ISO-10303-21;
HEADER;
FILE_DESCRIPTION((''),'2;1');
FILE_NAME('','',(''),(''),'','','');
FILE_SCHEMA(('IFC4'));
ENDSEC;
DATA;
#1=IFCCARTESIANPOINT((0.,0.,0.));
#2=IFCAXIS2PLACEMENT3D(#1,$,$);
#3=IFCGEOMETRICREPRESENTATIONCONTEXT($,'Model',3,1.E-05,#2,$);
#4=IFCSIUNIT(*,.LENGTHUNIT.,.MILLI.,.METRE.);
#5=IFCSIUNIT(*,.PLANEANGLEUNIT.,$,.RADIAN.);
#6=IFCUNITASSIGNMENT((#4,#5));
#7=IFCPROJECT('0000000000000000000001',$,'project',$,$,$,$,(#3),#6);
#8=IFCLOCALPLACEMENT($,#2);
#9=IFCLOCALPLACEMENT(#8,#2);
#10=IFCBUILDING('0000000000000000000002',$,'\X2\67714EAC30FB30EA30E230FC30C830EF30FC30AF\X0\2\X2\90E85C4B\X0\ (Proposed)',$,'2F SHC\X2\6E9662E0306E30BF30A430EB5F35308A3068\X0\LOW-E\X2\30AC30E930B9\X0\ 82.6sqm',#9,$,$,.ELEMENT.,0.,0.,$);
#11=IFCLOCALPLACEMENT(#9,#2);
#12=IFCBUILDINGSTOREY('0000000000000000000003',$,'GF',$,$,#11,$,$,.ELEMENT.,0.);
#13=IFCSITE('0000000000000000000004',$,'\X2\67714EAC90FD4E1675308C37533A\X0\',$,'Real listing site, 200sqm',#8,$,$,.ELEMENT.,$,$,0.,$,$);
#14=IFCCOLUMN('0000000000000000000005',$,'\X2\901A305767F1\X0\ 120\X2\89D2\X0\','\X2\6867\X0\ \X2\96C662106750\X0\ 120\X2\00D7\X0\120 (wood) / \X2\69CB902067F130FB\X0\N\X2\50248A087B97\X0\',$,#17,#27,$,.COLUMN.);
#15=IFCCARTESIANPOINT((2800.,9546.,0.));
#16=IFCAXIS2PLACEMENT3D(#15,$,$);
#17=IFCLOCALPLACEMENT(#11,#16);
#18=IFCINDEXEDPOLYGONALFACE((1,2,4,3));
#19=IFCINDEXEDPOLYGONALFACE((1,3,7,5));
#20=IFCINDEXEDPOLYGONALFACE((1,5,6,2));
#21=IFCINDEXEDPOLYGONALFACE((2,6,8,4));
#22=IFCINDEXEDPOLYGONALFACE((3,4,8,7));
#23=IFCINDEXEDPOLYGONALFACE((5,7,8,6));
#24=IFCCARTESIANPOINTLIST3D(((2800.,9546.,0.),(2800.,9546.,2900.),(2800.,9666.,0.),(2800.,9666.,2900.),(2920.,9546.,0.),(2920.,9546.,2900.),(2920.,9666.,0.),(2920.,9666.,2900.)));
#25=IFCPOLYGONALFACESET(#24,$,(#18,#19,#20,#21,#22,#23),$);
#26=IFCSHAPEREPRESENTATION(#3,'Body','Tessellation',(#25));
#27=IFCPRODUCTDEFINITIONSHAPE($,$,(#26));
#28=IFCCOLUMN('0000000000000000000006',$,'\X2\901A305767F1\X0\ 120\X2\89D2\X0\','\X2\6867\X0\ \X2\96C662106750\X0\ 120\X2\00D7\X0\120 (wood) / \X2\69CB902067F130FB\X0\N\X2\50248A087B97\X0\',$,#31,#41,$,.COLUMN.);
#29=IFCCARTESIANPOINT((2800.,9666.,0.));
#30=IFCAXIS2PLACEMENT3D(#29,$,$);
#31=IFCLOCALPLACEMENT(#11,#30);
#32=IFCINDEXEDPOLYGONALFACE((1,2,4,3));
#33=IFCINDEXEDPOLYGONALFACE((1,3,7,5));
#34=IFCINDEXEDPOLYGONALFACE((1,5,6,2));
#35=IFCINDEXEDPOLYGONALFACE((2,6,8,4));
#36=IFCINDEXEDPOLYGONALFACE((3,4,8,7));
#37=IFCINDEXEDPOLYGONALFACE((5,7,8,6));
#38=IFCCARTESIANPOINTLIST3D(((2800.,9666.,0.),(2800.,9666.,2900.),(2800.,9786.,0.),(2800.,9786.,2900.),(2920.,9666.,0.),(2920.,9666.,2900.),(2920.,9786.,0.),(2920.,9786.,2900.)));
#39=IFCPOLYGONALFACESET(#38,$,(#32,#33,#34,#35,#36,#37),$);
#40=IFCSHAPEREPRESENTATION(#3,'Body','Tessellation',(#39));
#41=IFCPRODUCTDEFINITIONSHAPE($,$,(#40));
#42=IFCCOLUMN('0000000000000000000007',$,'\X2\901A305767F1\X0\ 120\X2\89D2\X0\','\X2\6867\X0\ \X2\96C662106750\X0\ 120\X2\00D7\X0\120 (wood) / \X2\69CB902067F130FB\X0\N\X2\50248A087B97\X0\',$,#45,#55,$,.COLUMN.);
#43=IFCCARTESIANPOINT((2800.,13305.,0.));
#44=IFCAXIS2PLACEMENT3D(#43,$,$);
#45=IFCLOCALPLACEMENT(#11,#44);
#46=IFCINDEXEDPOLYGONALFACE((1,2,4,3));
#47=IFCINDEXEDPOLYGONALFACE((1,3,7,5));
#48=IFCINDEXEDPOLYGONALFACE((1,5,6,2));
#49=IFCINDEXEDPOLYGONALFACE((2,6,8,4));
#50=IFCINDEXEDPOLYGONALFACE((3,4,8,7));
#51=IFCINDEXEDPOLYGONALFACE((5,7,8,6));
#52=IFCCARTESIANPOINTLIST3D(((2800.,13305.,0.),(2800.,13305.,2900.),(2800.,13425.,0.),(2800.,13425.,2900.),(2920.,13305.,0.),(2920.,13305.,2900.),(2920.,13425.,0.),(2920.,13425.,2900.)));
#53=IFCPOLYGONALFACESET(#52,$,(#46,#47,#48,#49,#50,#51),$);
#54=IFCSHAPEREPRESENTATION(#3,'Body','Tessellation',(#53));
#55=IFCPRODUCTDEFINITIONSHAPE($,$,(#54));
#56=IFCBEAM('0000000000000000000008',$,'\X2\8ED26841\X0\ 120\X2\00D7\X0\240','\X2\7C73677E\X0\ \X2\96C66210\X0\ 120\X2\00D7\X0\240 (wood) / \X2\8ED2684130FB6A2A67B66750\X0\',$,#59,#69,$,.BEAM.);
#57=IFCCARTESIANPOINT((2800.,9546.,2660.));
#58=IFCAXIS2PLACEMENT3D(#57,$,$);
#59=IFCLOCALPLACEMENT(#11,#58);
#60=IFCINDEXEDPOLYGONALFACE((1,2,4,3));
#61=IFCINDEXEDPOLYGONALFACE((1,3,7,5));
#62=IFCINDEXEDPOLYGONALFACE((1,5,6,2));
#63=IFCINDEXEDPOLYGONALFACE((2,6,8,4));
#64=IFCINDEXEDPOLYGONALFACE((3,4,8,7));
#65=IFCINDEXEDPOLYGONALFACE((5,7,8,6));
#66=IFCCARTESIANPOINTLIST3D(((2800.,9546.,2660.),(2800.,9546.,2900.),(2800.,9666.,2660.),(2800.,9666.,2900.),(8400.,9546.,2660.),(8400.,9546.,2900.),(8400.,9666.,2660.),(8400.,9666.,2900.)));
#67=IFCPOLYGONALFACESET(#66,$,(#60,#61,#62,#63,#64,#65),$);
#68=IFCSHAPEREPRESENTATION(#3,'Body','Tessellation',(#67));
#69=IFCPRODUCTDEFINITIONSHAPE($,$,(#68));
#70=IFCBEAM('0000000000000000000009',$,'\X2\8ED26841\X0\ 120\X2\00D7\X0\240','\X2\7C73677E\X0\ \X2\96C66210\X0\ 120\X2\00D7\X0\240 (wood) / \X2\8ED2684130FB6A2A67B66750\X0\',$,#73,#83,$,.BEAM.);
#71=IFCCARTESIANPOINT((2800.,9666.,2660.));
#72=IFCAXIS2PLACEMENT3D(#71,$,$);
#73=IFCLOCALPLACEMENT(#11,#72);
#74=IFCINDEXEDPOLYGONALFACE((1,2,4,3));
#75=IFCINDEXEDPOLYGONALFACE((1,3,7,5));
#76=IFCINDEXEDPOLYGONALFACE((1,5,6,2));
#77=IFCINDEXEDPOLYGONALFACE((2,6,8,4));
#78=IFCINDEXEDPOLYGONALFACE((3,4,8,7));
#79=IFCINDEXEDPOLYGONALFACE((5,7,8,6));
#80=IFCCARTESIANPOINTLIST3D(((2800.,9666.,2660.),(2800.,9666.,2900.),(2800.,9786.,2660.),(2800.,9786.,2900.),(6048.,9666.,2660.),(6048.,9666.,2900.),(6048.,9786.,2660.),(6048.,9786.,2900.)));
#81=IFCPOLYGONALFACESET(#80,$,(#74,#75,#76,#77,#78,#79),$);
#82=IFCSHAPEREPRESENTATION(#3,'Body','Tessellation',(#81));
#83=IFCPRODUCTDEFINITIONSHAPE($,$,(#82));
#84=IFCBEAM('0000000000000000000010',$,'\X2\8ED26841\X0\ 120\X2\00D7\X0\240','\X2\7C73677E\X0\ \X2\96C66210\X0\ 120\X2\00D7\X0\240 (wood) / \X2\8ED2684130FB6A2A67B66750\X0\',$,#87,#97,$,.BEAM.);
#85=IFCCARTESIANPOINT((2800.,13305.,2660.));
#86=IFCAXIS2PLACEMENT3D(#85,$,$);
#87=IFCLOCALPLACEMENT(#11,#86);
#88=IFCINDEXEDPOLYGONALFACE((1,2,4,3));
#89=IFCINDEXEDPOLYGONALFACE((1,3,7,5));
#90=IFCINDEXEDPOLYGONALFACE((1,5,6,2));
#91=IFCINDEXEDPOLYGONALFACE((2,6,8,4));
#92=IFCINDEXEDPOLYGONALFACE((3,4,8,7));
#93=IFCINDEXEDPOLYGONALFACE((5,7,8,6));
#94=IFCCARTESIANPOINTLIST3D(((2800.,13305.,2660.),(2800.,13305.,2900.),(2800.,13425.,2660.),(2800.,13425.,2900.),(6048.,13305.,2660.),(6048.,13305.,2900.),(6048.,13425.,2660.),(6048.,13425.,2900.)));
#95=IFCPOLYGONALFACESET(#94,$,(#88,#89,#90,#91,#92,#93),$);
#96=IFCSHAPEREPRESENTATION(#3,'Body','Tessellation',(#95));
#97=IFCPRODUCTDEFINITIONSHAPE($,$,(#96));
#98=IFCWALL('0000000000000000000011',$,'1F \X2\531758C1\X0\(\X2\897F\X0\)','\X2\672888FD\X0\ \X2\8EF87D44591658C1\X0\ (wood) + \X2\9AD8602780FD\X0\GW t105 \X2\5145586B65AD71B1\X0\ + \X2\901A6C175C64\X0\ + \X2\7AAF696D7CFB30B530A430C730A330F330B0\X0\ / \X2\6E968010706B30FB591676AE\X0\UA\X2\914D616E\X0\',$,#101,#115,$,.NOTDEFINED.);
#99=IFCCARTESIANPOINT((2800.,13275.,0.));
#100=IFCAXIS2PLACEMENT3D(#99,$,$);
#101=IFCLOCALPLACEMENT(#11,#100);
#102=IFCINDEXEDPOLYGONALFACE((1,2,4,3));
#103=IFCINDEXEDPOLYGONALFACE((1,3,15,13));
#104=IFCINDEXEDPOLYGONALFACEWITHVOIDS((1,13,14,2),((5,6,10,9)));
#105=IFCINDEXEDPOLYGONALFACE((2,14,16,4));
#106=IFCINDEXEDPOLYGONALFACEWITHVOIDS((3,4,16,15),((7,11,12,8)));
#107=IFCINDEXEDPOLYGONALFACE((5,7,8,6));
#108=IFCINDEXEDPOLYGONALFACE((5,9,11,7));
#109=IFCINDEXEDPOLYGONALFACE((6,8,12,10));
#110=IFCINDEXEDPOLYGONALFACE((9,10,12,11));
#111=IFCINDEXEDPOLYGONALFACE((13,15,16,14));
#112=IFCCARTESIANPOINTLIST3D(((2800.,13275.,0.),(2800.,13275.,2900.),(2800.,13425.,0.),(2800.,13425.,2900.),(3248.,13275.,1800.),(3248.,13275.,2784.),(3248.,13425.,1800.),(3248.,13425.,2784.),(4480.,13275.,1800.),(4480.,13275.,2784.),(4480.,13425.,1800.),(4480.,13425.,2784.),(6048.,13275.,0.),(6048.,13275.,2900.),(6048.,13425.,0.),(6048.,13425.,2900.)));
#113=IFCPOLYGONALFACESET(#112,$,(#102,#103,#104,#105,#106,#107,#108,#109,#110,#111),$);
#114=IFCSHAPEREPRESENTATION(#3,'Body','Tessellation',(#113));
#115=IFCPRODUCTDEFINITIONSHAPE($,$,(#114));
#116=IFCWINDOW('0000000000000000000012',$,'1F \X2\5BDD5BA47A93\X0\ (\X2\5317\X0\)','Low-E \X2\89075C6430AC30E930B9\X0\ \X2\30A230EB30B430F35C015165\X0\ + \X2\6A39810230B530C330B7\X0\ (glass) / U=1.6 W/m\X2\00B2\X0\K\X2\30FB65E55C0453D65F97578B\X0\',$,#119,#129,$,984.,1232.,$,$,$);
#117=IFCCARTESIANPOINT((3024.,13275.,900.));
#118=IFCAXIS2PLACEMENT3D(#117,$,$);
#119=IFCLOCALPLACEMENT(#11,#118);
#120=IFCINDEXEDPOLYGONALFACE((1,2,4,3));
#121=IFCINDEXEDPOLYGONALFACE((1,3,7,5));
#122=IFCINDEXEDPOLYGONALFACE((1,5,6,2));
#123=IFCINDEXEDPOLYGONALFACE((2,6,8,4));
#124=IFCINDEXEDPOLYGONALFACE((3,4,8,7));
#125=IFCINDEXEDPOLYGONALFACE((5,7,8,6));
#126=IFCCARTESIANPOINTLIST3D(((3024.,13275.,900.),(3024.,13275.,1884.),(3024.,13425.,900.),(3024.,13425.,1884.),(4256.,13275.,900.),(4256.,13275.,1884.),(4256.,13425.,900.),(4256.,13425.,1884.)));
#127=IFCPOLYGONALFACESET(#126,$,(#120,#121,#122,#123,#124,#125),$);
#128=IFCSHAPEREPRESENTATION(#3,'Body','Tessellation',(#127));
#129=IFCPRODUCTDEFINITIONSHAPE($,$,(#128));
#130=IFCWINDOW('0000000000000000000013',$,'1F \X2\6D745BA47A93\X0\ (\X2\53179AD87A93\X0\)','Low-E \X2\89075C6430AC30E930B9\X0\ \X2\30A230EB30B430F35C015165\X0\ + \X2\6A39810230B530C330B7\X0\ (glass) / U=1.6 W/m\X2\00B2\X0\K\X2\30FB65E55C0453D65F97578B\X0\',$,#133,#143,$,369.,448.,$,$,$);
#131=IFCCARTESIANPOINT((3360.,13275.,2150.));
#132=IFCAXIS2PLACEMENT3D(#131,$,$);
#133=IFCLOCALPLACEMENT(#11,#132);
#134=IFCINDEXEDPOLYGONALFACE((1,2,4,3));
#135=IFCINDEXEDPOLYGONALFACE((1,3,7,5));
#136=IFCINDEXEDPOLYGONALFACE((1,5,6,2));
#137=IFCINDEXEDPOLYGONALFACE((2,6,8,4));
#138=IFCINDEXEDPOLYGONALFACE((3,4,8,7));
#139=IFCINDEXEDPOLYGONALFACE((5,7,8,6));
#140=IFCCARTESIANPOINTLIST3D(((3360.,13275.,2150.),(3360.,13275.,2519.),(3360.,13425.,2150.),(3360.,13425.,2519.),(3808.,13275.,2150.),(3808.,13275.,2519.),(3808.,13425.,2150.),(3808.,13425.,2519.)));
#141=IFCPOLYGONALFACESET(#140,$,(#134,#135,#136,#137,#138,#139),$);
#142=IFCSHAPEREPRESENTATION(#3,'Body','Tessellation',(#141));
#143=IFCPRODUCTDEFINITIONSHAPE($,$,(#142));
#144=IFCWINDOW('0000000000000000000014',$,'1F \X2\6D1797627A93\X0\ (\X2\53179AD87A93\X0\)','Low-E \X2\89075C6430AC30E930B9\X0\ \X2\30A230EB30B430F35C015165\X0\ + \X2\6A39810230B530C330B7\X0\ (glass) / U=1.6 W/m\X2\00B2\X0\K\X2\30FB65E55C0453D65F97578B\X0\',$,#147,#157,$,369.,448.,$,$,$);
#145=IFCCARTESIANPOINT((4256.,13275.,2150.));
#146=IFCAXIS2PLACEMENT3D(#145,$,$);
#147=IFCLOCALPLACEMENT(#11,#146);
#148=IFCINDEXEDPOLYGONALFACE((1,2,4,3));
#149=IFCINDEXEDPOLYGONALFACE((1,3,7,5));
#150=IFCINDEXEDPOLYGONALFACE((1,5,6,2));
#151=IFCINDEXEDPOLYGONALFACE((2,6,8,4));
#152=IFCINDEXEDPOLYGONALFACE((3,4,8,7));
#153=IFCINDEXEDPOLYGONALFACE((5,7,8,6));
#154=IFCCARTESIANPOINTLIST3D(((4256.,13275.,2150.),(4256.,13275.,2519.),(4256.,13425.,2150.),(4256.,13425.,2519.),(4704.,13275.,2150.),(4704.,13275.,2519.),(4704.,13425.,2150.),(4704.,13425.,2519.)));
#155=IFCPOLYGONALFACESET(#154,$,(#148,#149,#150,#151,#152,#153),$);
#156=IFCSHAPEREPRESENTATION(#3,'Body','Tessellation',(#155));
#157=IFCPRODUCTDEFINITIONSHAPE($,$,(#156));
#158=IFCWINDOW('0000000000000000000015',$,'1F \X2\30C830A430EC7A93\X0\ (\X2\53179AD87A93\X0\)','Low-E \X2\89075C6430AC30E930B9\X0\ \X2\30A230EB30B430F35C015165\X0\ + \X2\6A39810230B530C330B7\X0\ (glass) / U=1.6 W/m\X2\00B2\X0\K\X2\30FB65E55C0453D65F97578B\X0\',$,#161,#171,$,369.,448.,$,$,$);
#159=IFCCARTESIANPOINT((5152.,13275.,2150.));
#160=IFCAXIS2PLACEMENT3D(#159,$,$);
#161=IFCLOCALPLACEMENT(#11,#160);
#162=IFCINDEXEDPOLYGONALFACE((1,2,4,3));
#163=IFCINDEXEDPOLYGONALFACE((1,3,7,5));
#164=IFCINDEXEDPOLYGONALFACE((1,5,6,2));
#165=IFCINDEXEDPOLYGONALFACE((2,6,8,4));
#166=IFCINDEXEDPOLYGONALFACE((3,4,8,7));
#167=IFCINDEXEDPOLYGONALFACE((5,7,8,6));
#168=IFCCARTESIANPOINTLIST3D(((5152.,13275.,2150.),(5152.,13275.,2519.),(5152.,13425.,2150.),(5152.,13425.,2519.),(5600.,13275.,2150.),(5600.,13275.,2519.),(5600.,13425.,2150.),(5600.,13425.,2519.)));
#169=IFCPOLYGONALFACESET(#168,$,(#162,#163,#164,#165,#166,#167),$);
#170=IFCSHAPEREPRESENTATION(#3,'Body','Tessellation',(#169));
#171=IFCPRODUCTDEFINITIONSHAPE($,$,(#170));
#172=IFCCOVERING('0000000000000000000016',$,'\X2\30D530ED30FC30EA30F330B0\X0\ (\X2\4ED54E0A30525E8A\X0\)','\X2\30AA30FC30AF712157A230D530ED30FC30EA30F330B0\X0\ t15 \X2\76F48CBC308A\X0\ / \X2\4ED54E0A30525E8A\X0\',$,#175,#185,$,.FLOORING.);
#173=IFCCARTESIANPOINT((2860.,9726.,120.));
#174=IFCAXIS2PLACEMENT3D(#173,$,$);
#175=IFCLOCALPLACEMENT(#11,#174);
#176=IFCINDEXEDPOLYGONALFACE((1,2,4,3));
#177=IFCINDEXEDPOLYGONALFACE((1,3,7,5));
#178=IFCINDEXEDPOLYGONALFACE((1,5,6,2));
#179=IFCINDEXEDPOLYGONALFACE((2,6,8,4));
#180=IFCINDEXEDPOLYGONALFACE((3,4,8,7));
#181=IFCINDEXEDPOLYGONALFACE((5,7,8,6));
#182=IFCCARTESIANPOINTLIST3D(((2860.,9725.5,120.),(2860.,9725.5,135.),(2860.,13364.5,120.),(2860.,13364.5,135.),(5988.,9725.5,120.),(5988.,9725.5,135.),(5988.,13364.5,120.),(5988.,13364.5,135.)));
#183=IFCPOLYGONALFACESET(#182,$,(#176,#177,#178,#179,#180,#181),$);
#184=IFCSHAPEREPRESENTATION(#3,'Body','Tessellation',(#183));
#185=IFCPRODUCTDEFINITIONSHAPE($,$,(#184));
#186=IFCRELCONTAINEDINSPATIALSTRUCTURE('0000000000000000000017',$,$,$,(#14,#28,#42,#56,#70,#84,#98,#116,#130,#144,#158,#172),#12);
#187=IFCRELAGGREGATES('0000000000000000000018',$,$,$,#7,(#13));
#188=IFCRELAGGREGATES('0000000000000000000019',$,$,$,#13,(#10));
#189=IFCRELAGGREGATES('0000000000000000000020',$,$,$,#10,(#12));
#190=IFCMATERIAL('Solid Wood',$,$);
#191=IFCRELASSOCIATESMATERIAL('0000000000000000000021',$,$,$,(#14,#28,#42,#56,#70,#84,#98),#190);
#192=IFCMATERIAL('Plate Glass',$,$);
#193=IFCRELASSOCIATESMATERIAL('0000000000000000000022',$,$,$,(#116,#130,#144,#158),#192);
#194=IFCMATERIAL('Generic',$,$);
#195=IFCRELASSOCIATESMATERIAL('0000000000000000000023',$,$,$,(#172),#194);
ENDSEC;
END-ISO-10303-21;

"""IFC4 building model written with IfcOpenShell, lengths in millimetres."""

from ifc_helpers import new_model, si_unit, frame, frame_2d, origin, place, context, project, spatial, rectangle, extrude, material, element, fill, save


model = new_model("IFC4")

# Units and contexts
model_context = context("Model", 3, precision=1e-05, world=origin())
ifc_project = project(units=[si_unit("LENGTHUNIT", "METRE", prefix="MILLI"), si_unit("PLANEANGLEUNIT", "RADIAN")], contexts=[model_context])

# Site, building, storey
site_placement = place(None, origin())
site = spatial("IfcSite", under=ifc_project, at=site_placement, Name="東京都世田谷区", ObjectType="Real listing site, 200sqm", CompositionType="ELEMENT", RefElevation=0.0)
building_placement = place(site_placement, origin())
building = spatial("IfcBuilding", under=site, at=building_placement, Name="東京・リモートワーク2部屋 (Proposed)", ObjectType="2F SHC準拠のタイル張りとLOW-Eガラス 82.6sqm", CompositionType="ELEMENT", ElevationOfRefHeight=0.0, ElevationOfTerrain=0.0)
storey_placement = place(building_placement, origin())
storey = spatial("IfcBuildingStorey", under=building, at=storey_placement, Name="GF", CompositionType="ELEMENT", Elevation=0.0)

# Columns
ifc_material_1 = material(Name="Solid Wood")
column_1_placement = place(storey_placement, frame((2800.0, 9546.0, 0.0)))
element("IfcColumn", 1, at=column_1_placement, inside=storey, material=ifc_material_1, Name="通し柱 120角", Description="桧 集成材 120×120 (wood) / 構造柱・N値計算", PredefinedType="COLUMN", context=model_context, shape_type="SweptSolid", body=[
    extrude(rectangle(XDim=120.0, YDim=120.0, at=frame_2d((60.0, 60.0))), frame((2800.0, 9546.0, 0.0)), (0.0, 0.0, 1.0), 2900.0),
])
column_2_placement = place(storey_placement, frame((2800.0, 9666.0, 0.0)))
element("IfcColumn", 2, at=column_2_placement, inside=storey, material=ifc_material_1, Name="通し柱 120角", Description="桧 集成材 120×120 (wood) / 構造柱・N値計算", PredefinedType="COLUMN", context=model_context, shape_type="SweptSolid", body=[
    extrude(rectangle(XDim=120.0, YDim=120.0, at=frame_2d((60.0, 60.0))), frame((2800.0, 9666.0, 0.0)), (0.0, 0.0, 1.0), 2900.0),
])
column_3_placement = place(storey_placement, frame((2800.0, 13305.0, 0.0)))
element("IfcColumn", 3, at=column_3_placement, inside=storey, material=ifc_material_1, Name="通し柱 120角", Description="桧 集成材 120×120 (wood) / 構造柱・N値計算", PredefinedType="COLUMN", context=model_context, shape_type="SweptSolid", body=[
    extrude(rectangle(XDim=120.0, YDim=120.0, at=frame_2d((60.0, 60.0))), frame((2800.0, 13305.0, 0.0)), (0.0, 0.0, 1.0), 2900.0),
])

# Beams
beam_1_placement = place(storey_placement, frame((2800.0, 9546.0, 2660.0)))
element("IfcBeam", 4, at=beam_1_placement, inside=storey, material=ifc_material_1, Name="軒桁 120×240", Description="米松 集成 120×240 (wood) / 軒桁・横架材", PredefinedType="BEAM", context=model_context, shape_type="SweptSolid", body=[
    extrude(rectangle(XDim=5600.0, YDim=120.0, at=frame_2d((2800.0, 60.0))), frame((2800.0, 9546.0, 2660.0)), (0.0, 0.0, 1.0), 240.0),
])
beam_2_placement = place(storey_placement, frame((2800.0, 9666.0, 2660.0)))
element("IfcBeam", 5, at=beam_2_placement, inside=storey, material=ifc_material_1, Name="軒桁 120×240", Description="米松 集成 120×240 (wood) / 軒桁・横架材", PredefinedType="BEAM", context=model_context, shape_type="SweptSolid", body=[
    extrude(rectangle(XDim=3248.0, YDim=120.0, at=frame_2d((1624.0, 60.0))), frame((2800.0, 9666.0, 2660.0)), (0.0, 0.0, 1.0), 240.0),
])
beam_3_placement = place(storey_placement, frame((2800.0, 13305.0, 2660.0)))
element("IfcBeam", 6, at=beam_3_placement, inside=storey, material=ifc_material_1, Name="軒桁 120×240", Description="米松 集成 120×240 (wood) / 軒桁・横架材", PredefinedType="BEAM", context=model_context, shape_type="SweptSolid", body=[
    extrude(rectangle(XDim=3248.0, YDim=120.0, at=frame_2d((1624.0, 60.0))), frame((2800.0, 13305.0, 2660.0)), (0.0, 0.0, 1.0), 240.0),
])

# Wall, openings, windows
wall_1_placement = place(storey_placement, frame((2800.0, 13275.0, 0.0)))
wall_1 = element("IfcWall", 7, at=wall_1_placement, inside=storey, material=ifc_material_1, Name="1F 北壁(西)", Description="木製 軸組外壁 (wood) + 高性能GW t105 充填断熱 + 通気層 + 窯業系サイディング / 準耐火・外皮UA配慮", PredefinedType="NOTDEFINED", context=model_context, shape_type="SweptSolid", body=[
    extrude(rectangle(XDim=3248.0, YDim=150.0, at=frame_2d((1624.0, 75.0))), frame((2800.0, 13275.0, 0.0)), (0.0, 0.0, 1.0), 2900.0),
])
opening_1_placement = place(storey_placement, frame((3024.0, 13275.0, 900.0)))
opening_1 = element("IfcOpeningElement", 8, at=opening_1_placement, cuts=wall_1, PredefinedType="NOTDEFINED", context=model_context, shape_type="SweptSolid", body=[
    extrude(rectangle(XDim=1232.0, YDim=150.0, at=frame_2d((616.0, 75.0))), frame((3024.0, 13275.0, 900.0)), (0.0, 0.0, 1.0), 984.0),
])
opening_2_placement = place(storey_placement, frame((3360.0, 13275.0, 2150.0)))
opening_2 = element("IfcOpeningElement", 9, at=opening_2_placement, cuts=wall_1, PredefinedType="NOTDEFINED", context=model_context, shape_type="SweptSolid", body=[
    extrude(rectangle(XDim=448.0, YDim=150.0, at=frame_2d((224.0, 75.0))), frame((3360.0, 13275.0, 2150.0)), (0.0, 0.0, 1.0), 369.0),
])
opening_3_placement = place(storey_placement, frame((4256.0, 13275.0, 2150.0)))
opening_3 = element("IfcOpeningElement", 10, at=opening_3_placement, cuts=wall_1, PredefinedType="NOTDEFINED", context=model_context, shape_type="SweptSolid", body=[
    extrude(rectangle(XDim=448.0, YDim=150.0, at=frame_2d((224.0, 75.0))), frame((4256.0, 13275.0, 2150.0)), (0.0, 0.0, 1.0), 369.0),
])
opening_4_placement = place(storey_placement, frame((5152.0, 13275.0, 2150.0)))
opening_4 = element("IfcOpeningElement", 11, at=opening_4_placement, cuts=wall_1, PredefinedType="NOTDEFINED", context=model_context, shape_type="SweptSolid", body=[
    extrude(rectangle(XDim=448.0, YDim=150.0, at=frame_2d((224.0, 75.0))), frame((5152.0, 13275.0, 2150.0)), (0.0, 0.0, 1.0), 369.0),
])
ifc_material_2 = material(Name="Plate Glass")
window_1_placement = place(storey_placement, frame((3024.0, 13275.0, 900.0)))
window_1 = element("IfcWindow", 12, at=window_1_placement, inside=storey, material=ifc_material_2, Name="1F 寝室窓 (北)", Description="Low-E 複層ガラス アルゴン封入 + 樹脂サッシ (glass) / U=1.6 W/m²K・日射取得型", OverallHeight=984.0, OverallWidth=1232.0, context=model_context, shape_type="SweptSolid", body=[
    extrude(rectangle(XDim=1232.0, YDim=150.0, at=frame_2d((616.0, 75.0))), frame((3024.0, 13275.0, 900.0)), (0.0, 0.0, 1.0), 984.0),
])
fill(opening_1, window_1)
window_2_placement = place(storey_placement, frame((3360.0, 13275.0, 2150.0)))
window_2 = element("IfcWindow", 13, at=window_2_placement, inside=storey, material=ifc_material_2, Name="1F 浴室窓 (北高窓)", Description="Low-E 複層ガラス アルゴン封入 + 樹脂サッシ (glass) / U=1.6 W/m²K・日射取得型", OverallHeight=369.0, OverallWidth=448.0, context=model_context, shape_type="SweptSolid", body=[
    extrude(rectangle(XDim=448.0, YDim=150.0, at=frame_2d((224.0, 75.0))), frame((3360.0, 13275.0, 2150.0)), (0.0, 0.0, 1.0), 369.0),
])
fill(opening_2, window_2)
window_3_placement = place(storey_placement, frame((4256.0, 13275.0, 2150.0)))
window_3 = element("IfcWindow", 14, at=window_3_placement, inside=storey, material=ifc_material_2, Name="1F 洗面窓 (北高窓)", Description="Low-E 複層ガラス アルゴン封入 + 樹脂サッシ (glass) / U=1.6 W/m²K・日射取得型", OverallHeight=369.0, OverallWidth=448.0, context=model_context, shape_type="SweptSolid", body=[
    extrude(rectangle(XDim=448.0, YDim=150.0, at=frame_2d((224.0, 75.0))), frame((4256.0, 13275.0, 2150.0)), (0.0, 0.0, 1.0), 369.0),
])
fill(opening_3, window_3)
window_4_placement = place(storey_placement, frame((5152.0, 13275.0, 2150.0)))
window_4 = element("IfcWindow", 15, at=window_4_placement, inside=storey, material=ifc_material_2, Name="1F トイレ窓 (北高窓)", Description="Low-E 複層ガラス アルゴン封入 + 樹脂サッシ (glass) / U=1.6 W/m²K・日射取得型", OverallHeight=369.0, OverallWidth=448.0, context=model_context, shape_type="SweptSolid", body=[
    extrude(rectangle(XDim=448.0, YDim=150.0, at=frame_2d((224.0, 75.0))), frame((5152.0, 13275.0, 2150.0)), (0.0, 0.0, 1.0), 369.0),
])
fill(opening_4, window_4)

# Covering
ifc_material_3 = material(Name="Generic")
covering_placement = place(storey_placement, frame((2860.0, 9726.0, 120.0)))
element("IfcCovering", 16, at=covering_placement, inside=storey, material=ifc_material_3, Name="フローリング (仕上げ床)", Description="オーク無垢フローリング t15 直貼り / 仕上げ床", PredefinedType="FLOORING", context=model_context, shape_type="SweptSolid", body=[
    extrude(rectangle(XDim=3128.0, YDim=3639.0, at=frame_2d((1564.0, 1819.0))), frame((2860.0, 9726.0, 120.0)), (0.0, 0.0, 1.0), 15.0),
])

save(model, "model.ifc")
